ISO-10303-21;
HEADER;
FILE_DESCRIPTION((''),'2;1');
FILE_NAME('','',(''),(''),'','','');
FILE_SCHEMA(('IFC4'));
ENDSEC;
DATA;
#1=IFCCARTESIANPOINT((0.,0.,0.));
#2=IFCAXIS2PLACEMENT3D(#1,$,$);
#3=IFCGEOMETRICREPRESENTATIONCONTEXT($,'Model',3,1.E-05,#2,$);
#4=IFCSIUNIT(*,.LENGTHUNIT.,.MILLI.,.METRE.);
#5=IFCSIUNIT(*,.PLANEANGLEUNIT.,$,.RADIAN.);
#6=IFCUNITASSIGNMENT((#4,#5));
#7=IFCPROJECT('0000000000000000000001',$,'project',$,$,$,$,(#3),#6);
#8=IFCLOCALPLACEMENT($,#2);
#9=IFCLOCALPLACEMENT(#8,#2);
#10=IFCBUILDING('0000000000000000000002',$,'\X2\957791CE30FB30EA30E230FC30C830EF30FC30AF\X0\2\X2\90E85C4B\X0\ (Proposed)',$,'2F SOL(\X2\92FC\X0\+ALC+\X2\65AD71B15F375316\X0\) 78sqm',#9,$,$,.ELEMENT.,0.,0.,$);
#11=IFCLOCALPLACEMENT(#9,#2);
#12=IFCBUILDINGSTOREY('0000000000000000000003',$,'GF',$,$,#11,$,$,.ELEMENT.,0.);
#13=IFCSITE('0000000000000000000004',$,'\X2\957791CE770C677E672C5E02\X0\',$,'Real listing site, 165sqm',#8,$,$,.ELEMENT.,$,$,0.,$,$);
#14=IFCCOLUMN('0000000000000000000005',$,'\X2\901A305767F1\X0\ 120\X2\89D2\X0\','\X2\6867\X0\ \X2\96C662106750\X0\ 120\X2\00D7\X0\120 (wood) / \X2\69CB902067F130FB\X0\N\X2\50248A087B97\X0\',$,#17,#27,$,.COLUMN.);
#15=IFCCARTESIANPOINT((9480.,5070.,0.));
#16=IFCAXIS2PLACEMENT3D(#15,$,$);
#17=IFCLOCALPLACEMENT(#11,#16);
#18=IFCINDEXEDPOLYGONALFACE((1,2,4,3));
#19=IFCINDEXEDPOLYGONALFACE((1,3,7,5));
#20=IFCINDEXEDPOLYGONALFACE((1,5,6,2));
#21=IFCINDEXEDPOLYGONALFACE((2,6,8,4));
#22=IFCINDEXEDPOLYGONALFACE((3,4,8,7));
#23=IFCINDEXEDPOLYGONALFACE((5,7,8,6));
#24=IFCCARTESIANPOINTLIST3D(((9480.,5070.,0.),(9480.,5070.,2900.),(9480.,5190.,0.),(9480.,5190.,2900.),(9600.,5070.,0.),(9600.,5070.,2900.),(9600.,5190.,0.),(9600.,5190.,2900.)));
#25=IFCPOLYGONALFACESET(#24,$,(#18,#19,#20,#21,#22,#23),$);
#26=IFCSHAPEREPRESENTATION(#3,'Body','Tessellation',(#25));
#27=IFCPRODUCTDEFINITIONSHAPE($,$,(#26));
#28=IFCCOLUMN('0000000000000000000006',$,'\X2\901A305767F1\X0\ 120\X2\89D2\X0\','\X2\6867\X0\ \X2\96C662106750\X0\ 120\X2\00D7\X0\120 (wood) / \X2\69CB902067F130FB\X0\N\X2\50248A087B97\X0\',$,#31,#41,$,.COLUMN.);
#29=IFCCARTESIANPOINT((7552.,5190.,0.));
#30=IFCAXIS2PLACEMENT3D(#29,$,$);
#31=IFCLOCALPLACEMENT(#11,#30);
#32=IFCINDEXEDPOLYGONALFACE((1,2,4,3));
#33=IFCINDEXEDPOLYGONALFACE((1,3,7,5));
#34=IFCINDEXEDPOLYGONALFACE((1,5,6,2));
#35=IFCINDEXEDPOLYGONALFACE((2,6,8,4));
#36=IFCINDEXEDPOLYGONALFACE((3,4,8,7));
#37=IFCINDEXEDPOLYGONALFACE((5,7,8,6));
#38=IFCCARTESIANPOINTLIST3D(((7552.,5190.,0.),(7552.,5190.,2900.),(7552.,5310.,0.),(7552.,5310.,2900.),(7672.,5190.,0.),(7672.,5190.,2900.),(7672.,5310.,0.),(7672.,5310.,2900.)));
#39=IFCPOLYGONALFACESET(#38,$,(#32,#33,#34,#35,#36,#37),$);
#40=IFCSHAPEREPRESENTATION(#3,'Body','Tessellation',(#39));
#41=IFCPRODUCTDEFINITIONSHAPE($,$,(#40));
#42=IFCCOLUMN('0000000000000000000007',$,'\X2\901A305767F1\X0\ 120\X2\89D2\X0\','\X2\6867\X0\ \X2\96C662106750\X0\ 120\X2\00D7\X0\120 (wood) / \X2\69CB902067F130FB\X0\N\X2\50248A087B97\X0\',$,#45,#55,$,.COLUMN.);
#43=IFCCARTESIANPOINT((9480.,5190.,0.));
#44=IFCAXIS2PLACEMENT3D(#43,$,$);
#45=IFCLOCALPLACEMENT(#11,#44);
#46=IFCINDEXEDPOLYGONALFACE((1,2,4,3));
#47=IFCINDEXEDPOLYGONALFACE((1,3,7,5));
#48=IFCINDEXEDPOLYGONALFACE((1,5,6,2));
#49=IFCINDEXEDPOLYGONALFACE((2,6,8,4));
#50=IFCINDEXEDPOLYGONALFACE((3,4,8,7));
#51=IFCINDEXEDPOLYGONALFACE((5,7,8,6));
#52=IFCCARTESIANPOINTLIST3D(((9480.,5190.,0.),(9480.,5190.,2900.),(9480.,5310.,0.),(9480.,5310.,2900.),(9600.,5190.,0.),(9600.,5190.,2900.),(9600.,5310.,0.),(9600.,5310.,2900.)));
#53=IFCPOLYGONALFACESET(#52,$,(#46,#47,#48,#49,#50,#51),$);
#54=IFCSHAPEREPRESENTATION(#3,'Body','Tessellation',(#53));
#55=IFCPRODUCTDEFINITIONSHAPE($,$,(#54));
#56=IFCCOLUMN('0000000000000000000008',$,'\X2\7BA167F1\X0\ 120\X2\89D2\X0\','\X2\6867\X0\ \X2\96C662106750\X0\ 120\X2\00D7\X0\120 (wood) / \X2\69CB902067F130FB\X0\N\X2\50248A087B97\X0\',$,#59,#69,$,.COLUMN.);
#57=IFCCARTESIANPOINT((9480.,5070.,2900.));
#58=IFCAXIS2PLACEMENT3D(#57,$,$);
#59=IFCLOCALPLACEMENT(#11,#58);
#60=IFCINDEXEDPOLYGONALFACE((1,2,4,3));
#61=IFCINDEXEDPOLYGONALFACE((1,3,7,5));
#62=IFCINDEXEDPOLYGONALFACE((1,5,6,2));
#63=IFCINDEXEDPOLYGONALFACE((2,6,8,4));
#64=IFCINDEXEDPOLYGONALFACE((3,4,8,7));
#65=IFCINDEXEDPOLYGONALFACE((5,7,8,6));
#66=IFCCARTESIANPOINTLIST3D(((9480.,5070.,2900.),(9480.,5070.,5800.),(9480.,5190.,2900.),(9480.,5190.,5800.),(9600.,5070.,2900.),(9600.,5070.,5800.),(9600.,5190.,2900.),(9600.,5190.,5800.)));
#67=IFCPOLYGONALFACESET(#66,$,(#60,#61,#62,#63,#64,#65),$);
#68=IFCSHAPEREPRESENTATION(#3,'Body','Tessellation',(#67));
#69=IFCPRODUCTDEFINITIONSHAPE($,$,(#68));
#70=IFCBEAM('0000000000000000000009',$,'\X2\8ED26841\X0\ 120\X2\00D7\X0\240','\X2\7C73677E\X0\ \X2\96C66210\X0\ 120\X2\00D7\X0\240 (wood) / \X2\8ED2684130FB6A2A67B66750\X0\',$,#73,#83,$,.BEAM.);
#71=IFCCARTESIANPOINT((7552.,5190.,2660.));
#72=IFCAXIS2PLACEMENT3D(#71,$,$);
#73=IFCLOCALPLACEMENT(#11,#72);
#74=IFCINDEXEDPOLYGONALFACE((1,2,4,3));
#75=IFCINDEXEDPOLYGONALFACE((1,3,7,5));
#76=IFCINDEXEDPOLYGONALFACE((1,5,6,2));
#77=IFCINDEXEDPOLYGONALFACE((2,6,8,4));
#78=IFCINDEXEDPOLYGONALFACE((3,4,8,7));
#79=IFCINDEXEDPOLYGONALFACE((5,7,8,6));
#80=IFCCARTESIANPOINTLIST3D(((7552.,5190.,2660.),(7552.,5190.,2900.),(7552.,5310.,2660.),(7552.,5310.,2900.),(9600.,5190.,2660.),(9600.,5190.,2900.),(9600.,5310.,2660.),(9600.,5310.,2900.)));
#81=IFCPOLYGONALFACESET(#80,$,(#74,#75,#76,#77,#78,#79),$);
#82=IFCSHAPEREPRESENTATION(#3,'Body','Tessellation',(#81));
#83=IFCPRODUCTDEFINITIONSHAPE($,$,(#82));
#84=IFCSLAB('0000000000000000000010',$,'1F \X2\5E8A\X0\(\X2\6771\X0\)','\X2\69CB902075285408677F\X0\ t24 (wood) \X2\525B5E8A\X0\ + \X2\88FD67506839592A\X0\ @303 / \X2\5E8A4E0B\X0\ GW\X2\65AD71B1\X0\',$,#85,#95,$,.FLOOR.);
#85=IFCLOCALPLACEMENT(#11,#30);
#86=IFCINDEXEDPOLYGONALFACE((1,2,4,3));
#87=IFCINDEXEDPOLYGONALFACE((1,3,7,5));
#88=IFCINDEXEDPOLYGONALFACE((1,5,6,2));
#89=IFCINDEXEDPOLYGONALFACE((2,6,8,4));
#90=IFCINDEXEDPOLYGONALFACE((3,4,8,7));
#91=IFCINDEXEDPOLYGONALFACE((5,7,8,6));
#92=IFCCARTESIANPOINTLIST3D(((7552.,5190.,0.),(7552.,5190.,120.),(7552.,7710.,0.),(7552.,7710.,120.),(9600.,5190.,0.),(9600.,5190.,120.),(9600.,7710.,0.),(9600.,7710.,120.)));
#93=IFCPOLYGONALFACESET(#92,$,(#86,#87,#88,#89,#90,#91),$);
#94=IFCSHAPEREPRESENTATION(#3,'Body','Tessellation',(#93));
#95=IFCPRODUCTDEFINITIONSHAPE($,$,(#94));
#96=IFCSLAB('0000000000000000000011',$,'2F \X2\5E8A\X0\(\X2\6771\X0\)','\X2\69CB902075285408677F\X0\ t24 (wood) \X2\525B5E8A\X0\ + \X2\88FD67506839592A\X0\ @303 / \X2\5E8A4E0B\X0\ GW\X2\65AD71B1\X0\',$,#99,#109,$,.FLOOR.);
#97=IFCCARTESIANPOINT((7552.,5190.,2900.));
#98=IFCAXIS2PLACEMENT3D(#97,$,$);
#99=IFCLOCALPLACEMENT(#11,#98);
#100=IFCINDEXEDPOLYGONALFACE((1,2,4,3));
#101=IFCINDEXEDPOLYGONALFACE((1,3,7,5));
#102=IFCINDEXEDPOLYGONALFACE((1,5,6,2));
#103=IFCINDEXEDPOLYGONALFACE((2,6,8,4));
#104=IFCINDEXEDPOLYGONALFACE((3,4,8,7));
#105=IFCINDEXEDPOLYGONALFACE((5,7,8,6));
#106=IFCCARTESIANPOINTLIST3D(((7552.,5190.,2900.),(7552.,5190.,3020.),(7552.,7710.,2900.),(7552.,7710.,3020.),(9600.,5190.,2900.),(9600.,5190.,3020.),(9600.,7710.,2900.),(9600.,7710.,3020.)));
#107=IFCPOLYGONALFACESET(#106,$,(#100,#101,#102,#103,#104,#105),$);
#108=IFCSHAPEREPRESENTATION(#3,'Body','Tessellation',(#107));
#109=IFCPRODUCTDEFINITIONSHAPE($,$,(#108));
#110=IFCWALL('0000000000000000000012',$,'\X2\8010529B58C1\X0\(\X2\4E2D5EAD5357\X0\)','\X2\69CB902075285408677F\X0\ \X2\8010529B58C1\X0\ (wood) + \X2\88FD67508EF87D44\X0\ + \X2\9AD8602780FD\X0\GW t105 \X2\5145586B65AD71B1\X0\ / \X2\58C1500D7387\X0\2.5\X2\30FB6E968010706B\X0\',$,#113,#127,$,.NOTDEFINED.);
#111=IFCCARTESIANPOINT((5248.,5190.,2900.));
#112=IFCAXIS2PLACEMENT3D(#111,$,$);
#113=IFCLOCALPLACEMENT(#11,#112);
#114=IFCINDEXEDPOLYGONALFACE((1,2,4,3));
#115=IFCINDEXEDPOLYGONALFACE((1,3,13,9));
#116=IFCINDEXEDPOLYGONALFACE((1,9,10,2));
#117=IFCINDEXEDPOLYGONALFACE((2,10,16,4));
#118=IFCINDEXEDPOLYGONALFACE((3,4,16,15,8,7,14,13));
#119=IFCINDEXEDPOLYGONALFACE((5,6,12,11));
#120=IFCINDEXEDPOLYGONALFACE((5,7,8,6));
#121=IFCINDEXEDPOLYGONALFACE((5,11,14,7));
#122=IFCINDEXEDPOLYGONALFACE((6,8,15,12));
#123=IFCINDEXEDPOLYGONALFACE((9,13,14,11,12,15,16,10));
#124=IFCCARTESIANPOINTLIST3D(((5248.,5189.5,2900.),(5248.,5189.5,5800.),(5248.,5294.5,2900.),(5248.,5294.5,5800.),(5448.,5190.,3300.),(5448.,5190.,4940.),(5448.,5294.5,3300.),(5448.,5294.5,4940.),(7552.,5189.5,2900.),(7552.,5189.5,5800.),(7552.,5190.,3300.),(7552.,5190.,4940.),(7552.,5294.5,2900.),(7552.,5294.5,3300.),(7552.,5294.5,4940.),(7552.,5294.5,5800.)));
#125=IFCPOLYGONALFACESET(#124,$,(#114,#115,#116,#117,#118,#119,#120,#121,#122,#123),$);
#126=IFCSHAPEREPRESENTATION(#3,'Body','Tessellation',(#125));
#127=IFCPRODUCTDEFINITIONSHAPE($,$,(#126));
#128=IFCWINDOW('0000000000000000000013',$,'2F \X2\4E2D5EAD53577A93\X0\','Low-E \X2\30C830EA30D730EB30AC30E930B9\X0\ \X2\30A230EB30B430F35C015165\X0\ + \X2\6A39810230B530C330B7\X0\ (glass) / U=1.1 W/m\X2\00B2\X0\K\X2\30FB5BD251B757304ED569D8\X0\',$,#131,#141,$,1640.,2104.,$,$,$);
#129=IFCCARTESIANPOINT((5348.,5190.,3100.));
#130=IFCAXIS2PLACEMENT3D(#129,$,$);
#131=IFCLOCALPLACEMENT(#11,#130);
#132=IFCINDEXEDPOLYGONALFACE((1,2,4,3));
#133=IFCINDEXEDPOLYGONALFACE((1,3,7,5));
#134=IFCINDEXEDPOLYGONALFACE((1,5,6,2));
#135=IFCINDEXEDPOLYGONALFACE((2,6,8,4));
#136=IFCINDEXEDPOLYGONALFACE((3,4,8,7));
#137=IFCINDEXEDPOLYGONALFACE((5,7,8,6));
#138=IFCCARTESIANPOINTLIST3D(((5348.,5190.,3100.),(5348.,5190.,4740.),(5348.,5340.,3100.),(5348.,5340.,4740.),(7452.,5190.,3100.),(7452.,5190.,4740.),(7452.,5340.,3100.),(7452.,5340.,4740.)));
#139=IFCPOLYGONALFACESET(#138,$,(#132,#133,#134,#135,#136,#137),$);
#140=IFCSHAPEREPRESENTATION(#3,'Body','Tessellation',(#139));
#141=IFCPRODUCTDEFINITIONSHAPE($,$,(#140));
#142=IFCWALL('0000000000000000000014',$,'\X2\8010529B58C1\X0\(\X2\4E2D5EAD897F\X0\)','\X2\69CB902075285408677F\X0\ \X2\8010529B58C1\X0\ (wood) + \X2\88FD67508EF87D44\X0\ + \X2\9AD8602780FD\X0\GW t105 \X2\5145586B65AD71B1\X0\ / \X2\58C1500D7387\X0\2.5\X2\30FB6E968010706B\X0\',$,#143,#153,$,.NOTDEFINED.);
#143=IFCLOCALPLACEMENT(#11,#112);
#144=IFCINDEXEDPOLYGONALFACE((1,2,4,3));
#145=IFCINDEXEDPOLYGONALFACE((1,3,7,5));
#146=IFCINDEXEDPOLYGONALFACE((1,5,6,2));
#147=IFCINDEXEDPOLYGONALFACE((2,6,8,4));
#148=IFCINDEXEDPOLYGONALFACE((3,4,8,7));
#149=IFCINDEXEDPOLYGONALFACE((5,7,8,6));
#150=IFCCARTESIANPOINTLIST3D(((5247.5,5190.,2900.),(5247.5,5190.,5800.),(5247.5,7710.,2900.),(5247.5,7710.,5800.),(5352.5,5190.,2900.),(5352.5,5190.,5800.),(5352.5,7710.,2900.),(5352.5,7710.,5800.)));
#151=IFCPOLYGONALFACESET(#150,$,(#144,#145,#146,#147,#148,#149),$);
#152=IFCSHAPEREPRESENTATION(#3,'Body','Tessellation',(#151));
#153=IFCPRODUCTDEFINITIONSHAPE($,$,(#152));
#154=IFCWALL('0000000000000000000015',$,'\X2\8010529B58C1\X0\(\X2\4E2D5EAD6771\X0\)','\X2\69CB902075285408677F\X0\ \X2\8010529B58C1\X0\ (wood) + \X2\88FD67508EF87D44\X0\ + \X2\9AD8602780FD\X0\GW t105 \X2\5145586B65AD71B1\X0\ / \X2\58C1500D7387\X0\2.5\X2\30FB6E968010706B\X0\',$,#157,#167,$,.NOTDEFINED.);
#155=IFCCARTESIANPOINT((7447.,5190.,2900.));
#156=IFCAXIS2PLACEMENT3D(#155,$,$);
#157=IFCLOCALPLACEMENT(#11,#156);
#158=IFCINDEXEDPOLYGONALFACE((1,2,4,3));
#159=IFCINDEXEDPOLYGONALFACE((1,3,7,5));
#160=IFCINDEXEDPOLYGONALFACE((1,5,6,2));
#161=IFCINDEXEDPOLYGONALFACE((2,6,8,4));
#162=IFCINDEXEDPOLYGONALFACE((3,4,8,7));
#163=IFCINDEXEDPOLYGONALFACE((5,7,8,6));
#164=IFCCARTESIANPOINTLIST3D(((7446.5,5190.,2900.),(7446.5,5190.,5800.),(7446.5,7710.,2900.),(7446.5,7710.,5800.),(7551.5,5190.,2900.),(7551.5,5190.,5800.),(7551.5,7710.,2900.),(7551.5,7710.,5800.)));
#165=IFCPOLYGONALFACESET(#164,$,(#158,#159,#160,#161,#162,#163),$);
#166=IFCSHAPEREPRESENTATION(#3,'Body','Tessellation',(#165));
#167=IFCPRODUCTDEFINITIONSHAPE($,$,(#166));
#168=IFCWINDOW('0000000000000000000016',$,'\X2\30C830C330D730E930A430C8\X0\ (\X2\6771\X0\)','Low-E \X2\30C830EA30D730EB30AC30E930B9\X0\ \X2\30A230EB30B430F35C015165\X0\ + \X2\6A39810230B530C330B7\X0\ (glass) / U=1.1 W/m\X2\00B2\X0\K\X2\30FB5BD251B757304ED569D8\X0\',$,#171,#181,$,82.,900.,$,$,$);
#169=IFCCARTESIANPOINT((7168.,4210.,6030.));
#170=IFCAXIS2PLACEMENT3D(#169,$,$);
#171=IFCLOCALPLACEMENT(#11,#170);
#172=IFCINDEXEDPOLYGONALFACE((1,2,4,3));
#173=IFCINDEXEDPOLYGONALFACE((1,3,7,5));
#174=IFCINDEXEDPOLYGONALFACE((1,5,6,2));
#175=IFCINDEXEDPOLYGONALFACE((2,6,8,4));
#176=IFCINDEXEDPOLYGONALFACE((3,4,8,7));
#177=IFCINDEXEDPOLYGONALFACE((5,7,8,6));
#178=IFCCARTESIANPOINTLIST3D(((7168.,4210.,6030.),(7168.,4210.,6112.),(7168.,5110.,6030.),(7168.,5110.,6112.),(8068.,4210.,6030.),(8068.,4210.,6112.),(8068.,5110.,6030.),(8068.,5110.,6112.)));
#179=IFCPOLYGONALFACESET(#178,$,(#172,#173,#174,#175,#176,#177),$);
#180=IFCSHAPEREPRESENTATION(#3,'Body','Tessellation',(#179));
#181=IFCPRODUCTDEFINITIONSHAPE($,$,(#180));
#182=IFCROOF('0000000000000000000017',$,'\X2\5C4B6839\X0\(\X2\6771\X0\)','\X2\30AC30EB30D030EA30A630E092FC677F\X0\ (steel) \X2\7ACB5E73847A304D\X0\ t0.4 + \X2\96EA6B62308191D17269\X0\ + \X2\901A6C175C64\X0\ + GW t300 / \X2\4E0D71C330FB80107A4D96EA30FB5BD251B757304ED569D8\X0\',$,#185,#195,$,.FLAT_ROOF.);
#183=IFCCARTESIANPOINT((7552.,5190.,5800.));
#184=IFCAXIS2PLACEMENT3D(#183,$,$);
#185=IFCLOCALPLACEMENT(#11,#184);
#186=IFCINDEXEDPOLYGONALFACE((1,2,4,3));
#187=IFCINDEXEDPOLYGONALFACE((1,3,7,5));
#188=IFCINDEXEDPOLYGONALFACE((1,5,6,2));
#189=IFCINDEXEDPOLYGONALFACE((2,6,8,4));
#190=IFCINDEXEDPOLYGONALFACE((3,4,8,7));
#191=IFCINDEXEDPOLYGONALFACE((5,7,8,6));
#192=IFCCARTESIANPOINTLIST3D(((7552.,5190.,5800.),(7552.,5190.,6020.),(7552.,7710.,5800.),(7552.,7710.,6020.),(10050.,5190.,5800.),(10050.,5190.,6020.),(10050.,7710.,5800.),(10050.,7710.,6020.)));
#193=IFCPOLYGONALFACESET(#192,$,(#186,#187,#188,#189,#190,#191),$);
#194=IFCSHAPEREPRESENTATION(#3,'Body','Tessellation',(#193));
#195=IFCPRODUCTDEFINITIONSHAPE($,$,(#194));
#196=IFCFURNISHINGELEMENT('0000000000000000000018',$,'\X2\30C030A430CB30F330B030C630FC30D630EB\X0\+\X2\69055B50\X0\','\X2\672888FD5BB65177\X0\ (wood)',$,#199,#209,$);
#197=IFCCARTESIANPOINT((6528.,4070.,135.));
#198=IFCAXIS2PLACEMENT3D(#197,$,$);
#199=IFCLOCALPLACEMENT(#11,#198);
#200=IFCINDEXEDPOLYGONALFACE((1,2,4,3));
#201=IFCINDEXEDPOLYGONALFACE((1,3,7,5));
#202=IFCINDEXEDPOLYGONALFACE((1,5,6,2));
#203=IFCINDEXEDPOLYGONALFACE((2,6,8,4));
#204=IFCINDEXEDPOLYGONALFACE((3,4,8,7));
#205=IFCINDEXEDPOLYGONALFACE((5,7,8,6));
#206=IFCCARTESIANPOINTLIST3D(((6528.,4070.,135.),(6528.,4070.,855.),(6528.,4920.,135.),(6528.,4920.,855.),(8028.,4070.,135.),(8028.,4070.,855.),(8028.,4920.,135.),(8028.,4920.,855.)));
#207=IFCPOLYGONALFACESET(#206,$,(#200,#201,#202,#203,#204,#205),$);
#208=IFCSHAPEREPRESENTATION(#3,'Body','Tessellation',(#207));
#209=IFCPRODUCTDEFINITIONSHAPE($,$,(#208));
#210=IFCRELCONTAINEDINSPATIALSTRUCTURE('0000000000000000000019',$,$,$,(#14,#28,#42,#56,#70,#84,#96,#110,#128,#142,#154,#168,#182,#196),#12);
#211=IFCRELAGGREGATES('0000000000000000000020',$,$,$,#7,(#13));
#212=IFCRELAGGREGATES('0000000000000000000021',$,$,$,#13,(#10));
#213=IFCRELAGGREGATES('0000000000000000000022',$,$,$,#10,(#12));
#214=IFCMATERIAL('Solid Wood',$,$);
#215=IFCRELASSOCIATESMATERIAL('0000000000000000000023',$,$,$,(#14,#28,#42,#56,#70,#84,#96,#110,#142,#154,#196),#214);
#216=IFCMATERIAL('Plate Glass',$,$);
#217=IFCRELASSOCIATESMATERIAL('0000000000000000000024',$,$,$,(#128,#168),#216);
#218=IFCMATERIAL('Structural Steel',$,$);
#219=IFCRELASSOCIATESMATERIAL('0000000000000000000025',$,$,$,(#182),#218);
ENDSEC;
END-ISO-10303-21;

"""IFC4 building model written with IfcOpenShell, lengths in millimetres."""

from ifc_helpers import new_model, si_unit, frame, frame_2d, origin, place, context, project, spatial, rectangle, extrude, material, element, fill, save


model = new_model("IFC4")

# Units and contexts
model_context = context("Model", 3, precision=1e-05, world=origin())
ifc_project = project(units=[si_unit("LENGTHUNIT", "METRE", prefix="MILLI"), si_unit("PLANEANGLEUNIT", "RADIAN")], contexts=[model_context])

# Site, building, storey
site_placement = place(None, origin())
site = spatial("IfcSite", under=ifc_project, at=site_placement, Name="長野県松本市", ObjectType="Real listing site, 165sqm", CompositionType="ELEMENT", RefElevation=0.0)
building_placement = place(site_placement, origin())
building = spatial("IfcBuilding", under=site, at=building_placement, Name="長野・リモートワーク2部屋 (Proposed)", ObjectType="2F SOL(鋼+ALC+断熱強化) 78sqm", CompositionType="ELEMENT", ElevationOfRefHeight=0.0, ElevationOfTerrain=0.0)
storey_placement = place(building_placement, origin())
storey = spatial("IfcBuildingStorey", under=building, at=storey_placement, Name="GF", CompositionType="ELEMENT", Elevation=0.0)

# Columns
ifc_material_1 = material(Name="Solid Wood")
column_1_placement = place(storey_placement, frame((9480.0, 5070.0, 0.0)))
element("IfcColumn", 1, at=column_1_placement, inside=storey, material=ifc_material_1, Name="通し柱 120角", Description="桧 集成材 120×120 (wood) / 構造柱・N値計算", PredefinedType="COLUMN", context=model_context, shape_type="SweptSolid", body=[
    extrude(rectangle(XDim=120.0, YDim=120.0, at=frame_2d((60.0, 60.0))), frame((9480.0, 5070.0, 0.0)), (0.0, 0.0, 1.0), 2900.0),
])
column_2_placement = place(storey_placement, frame((7552.0, 5190.0, 0.0)))
element("IfcColumn", 2, at=column_2_placement, inside=storey, material=ifc_material_1, Name="通し柱 120角", Description="桧 集成材 120×120 (wood) / 構造柱・N値計算", PredefinedType="COLUMN", context=model_context, shape_type="SweptSolid", body=[
    extrude(rectangle(XDim=120.0, YDim=120.0, at=frame_2d((60.0, 60.0))), frame((7552.0, 5190.0, 0.0)), (0.0, 0.0, 1.0), 2900.0),
])
column_3_placement = place(storey_placement, frame((9480.0, 5190.0, 0.0)))
element("IfcColumn", 3, at=column_3_placement, inside=storey, material=ifc_material_1, Name="通し柱 120角", Description="桧 集成材 120×120 (wood) / 構造柱・N値計算", PredefinedType="COLUMN", context=model_context, shape_type="SweptSolid", body=[
    extrude(rectangle(XDim=120.0, YDim=120.0, at=frame_2d((60.0, 60.0))), frame((9480.0, 5190.0, 0.0)), (0.0, 0.0, 1.0), 2900.0),
])
column_4_placement = place(storey_placement, frame((9480.0, 5070.0, 2900.0)))
element("IfcColumn", 4, at=column_4_placement, inside=storey, material=ifc_material_1, Name="管柱 120角", Description="桧 集成材 120×120 (wood) / 構造柱・N値計算", PredefinedType="COLUMN", context=model_context, shape_type="SweptSolid", body=[
    extrude(rectangle(XDim=120.0, YDim=120.0, at=frame_2d((60.0, 60.0))), frame((9480.0, 5070.0, 2900.0)), (0.0, 0.0, 1.0), 2900.0),
])

# Beam
beam_1_placement = place(storey_placement, frame((7552.0, 5190.0, 2660.0)))
element("IfcBeam", 5, at=beam_1_placement, inside=storey, material=ifc_material_1, Name="軒桁 120×240", Description="米松 集成 120×240 (wood) / 軒桁・横架材", PredefinedType="BEAM", context=model_context, shape_type="SweptSolid", body=[
    extrude(rectangle(XDim=2048.0, YDim=120.0, at=frame_2d((1024.0, 60.0))), frame((7552.0, 5190.0, 2660.0)), (0.0, 0.0, 1.0), 240.0),
])

# Slabs
slab_1_placement = place(storey_placement, frame((7552.0, 5190.0, 0.0)))
element("IfcSlab", 6, at=slab_1_placement, inside=storey, material=ifc_material_1, Name="1F 床(東)", Description="構造用合板 t24 (wood) 剛床 + 製材根太 @303 / 床下 GW断熱", PredefinedType="FLOOR", context=model_context, shape_type="SweptSolid", body=[
    extrude(rectangle(XDim=2048.0, YDim=2520.0, at=frame_2d((1024.0, 1260.0))), frame((7552.0, 5190.0, 0.0)), (0.0, 0.0, 1.0), 120.0),
])
slab_2_placement = place(storey_placement, frame((7552.0, 5190.0, 2900.0)))
element("IfcSlab", 7, at=slab_2_placement, inside=storey, material=ifc_material_1, Name="2F 床(東)", Description="構造用合板 t24 (wood) 剛床 + 製材根太 @303 / 床下 GW断熱", PredefinedType="FLOOR", context=model_context, shape_type="SweptSolid", body=[
    extrude(rectangle(XDim=2048.0, YDim=2520.0, at=frame_2d((1024.0, 1260.0))), frame((7552.0, 5190.0, 2900.0)), (0.0, 0.0, 1.0), 120.0),
])

# Wall, opening, window
wall_1_placement = place(storey_placement, frame((5248.0, 5190.0, 2900.0)))
wall_1 = element("IfcWall", 8, at=wall_1_placement, inside=storey, material=ifc_material_1, Name="耐力壁(中庭南)", Description="構造用合板 耐力壁 (wood) + 製材軸組 + 高性能GW t105 充填断熱 / 壁倍率2.5・準耐火", PredefinedType="NOTDEFINED", context=model_context, shape_type="SweptSolid", body=[
    extrude(rectangle(XDim=2304.0, YDim=105.0, at=frame_2d((1152.0, 52.0))), frame((5248.0, 5190.0, 2900.0)), (0.0, 0.0, 1.0), 2900.0),
])
opening_placement = place(storey_placement, frame((5348.0, 5190.0, 3100.0)))
opening = element("IfcOpeningElement", 9, at=opening_placement, cuts=wall_1, PredefinedType="NOTDEFINED", context=model_context, shape_type="SweptSolid", body=[
    extrude(rectangle(XDim=2104.0, YDim=150.0, at=frame_2d((1052.0, 75.0))), frame((5348.0, 5190.0, 3100.0)), (0.0, 0.0, 1.0), 1640.0),
])
ifc_material_2 = material(Name="Plate Glass")
window_1_placement = place(storey_placement, frame((5348.0, 5190.0, 3100.0)))
window_1 = element("IfcWindow", 10, at=window_1_placement, inside=storey, material=ifc_material_2, Name="2F 中庭南窓", Description="Low-E トリプルガラス アルゴン封入 + 樹脂サッシ (glass) / U=1.1 W/m²K・寒冷地仕様", OverallHeight=1640.0, OverallWidth=2104.0, context=model_context, shape_type="SweptSolid", body=[
    extrude(rectangle(XDim=2104.0, YDim=150.0, at=frame_2d((1052.0, 75.0))), frame((5348.0, 5190.0, 3100.0)), (0.0, 0.0, 1.0), 1640.0),
])
fill(opening, window_1)

# Walls
wall_2_placement = place(storey_placement, frame((5248.0, 5190.0, 2900.0)))
element("IfcWall", 11, at=wall_2_placement, inside=storey, material=ifc_material_1, Name="耐力壁(中庭西)", Description="構造用合板 耐力壁 (wood) + 製材軸組 + 高性能GW t105 充填断熱 / 壁倍率2.5・準耐火", PredefinedType="NOTDEFINED", context=model_context, shape_type="SweptSolid", body=[
    extrude(rectangle(XDim=105.0, YDim=2520.0, at=frame_2d((52.0, 1260.0))), frame((5248.0, 5190.0, 2900.0)), (0.0, 0.0, 1.0), 2900.0),
])
wall_3_placement = place(storey_placement, frame((7447.0, 5190.0, 2900.0)))
element("IfcWall", 12, at=wall_3_placement, inside=storey, material=ifc_material_1, Name="耐力壁(中庭東)", Description="構造用合板 耐力壁 (wood) + 製材軸組 + 高性能GW t105 充填断熱 / 壁倍率2.5・準耐火", PredefinedType="NOTDEFINED", context=model_context, shape_type="SweptSolid", body=[
    extrude(rectangle(XDim=105.0, YDim=2520.0, at=frame_2d((52.0, 1260.0))), frame((7447.0, 5190.0, 2900.0)), (0.0, 0.0, 1.0), 2900.0),
])

# Window
window_2_placement = place(storey_placement, frame((7168.0, 4210.0, 6030.0)))
element("IfcWindow", 13, at=window_2_placement, inside=storey, material=ifc_material_2, Name="トップライト (東)", Description="Low-E トリプルガラス アルゴン封入 + 樹脂サッシ (glass) / U=1.1 W/m²K・寒冷地仕様", OverallHeight=82.0, OverallWidth=900.0, context=model_context, shape_type="SweptSolid", body=[
    extrude(rectangle(XDim=900.0, YDim=900.0, at=frame_2d((450.0, 450.0))), frame((7168.0, 4210.0, 6030.0)), (0.0, 0.0, 1.0), 82.0),
])

# Roof
ifc_material_3 = material(Name="Structural Steel")
for number, where, name in (
    (14, (7552.0, 5190.0, 5800.0), "屋根(東)"),
):
    element("IfcRoof", number, at=place(storey_placement, frame(where)), inside=storey, material=ifc_material_3, Name=name, Description="ガルバリウム鋼板 (steel) 立平葺き t0.4 + 雪止め金物 + 通気層 + GW t300 / 不燃・耐積雪・寒冷地仕様", PredefinedType="FLAT_ROOF", context=model_context, shape_type="SweptSolid", body=[
        extrude(rectangle(XDim=2498.0, YDim=2520.0, at=frame_2d((1249.0, 1260.0))), frame((7552.0, 5190.0, 5800.0)), (0.0, 0.0, 1.0), 220.0),
    ])

# Furnishing element
furnishing_1_placement = place(storey_placement, frame((6528.0, 4070.0, 135.0)))
element("IfcFurnishingElement", 15, at=furnishing_1_placement, inside=storey, material=ifc_material_1, Name="ダイニングテーブル+椅子", Description="木製家具 (wood)", context=model_context, shape_type="SweptSolid", body=[
    extrude(rectangle(XDim=1500.0, YDim=850.0, at=frame_2d((750.0, 425.0))), frame((6528.0, 4070.0, 135.0)), (0.0, 0.0, 1.0), 720.0),
])

save(model, "model.ifc")
